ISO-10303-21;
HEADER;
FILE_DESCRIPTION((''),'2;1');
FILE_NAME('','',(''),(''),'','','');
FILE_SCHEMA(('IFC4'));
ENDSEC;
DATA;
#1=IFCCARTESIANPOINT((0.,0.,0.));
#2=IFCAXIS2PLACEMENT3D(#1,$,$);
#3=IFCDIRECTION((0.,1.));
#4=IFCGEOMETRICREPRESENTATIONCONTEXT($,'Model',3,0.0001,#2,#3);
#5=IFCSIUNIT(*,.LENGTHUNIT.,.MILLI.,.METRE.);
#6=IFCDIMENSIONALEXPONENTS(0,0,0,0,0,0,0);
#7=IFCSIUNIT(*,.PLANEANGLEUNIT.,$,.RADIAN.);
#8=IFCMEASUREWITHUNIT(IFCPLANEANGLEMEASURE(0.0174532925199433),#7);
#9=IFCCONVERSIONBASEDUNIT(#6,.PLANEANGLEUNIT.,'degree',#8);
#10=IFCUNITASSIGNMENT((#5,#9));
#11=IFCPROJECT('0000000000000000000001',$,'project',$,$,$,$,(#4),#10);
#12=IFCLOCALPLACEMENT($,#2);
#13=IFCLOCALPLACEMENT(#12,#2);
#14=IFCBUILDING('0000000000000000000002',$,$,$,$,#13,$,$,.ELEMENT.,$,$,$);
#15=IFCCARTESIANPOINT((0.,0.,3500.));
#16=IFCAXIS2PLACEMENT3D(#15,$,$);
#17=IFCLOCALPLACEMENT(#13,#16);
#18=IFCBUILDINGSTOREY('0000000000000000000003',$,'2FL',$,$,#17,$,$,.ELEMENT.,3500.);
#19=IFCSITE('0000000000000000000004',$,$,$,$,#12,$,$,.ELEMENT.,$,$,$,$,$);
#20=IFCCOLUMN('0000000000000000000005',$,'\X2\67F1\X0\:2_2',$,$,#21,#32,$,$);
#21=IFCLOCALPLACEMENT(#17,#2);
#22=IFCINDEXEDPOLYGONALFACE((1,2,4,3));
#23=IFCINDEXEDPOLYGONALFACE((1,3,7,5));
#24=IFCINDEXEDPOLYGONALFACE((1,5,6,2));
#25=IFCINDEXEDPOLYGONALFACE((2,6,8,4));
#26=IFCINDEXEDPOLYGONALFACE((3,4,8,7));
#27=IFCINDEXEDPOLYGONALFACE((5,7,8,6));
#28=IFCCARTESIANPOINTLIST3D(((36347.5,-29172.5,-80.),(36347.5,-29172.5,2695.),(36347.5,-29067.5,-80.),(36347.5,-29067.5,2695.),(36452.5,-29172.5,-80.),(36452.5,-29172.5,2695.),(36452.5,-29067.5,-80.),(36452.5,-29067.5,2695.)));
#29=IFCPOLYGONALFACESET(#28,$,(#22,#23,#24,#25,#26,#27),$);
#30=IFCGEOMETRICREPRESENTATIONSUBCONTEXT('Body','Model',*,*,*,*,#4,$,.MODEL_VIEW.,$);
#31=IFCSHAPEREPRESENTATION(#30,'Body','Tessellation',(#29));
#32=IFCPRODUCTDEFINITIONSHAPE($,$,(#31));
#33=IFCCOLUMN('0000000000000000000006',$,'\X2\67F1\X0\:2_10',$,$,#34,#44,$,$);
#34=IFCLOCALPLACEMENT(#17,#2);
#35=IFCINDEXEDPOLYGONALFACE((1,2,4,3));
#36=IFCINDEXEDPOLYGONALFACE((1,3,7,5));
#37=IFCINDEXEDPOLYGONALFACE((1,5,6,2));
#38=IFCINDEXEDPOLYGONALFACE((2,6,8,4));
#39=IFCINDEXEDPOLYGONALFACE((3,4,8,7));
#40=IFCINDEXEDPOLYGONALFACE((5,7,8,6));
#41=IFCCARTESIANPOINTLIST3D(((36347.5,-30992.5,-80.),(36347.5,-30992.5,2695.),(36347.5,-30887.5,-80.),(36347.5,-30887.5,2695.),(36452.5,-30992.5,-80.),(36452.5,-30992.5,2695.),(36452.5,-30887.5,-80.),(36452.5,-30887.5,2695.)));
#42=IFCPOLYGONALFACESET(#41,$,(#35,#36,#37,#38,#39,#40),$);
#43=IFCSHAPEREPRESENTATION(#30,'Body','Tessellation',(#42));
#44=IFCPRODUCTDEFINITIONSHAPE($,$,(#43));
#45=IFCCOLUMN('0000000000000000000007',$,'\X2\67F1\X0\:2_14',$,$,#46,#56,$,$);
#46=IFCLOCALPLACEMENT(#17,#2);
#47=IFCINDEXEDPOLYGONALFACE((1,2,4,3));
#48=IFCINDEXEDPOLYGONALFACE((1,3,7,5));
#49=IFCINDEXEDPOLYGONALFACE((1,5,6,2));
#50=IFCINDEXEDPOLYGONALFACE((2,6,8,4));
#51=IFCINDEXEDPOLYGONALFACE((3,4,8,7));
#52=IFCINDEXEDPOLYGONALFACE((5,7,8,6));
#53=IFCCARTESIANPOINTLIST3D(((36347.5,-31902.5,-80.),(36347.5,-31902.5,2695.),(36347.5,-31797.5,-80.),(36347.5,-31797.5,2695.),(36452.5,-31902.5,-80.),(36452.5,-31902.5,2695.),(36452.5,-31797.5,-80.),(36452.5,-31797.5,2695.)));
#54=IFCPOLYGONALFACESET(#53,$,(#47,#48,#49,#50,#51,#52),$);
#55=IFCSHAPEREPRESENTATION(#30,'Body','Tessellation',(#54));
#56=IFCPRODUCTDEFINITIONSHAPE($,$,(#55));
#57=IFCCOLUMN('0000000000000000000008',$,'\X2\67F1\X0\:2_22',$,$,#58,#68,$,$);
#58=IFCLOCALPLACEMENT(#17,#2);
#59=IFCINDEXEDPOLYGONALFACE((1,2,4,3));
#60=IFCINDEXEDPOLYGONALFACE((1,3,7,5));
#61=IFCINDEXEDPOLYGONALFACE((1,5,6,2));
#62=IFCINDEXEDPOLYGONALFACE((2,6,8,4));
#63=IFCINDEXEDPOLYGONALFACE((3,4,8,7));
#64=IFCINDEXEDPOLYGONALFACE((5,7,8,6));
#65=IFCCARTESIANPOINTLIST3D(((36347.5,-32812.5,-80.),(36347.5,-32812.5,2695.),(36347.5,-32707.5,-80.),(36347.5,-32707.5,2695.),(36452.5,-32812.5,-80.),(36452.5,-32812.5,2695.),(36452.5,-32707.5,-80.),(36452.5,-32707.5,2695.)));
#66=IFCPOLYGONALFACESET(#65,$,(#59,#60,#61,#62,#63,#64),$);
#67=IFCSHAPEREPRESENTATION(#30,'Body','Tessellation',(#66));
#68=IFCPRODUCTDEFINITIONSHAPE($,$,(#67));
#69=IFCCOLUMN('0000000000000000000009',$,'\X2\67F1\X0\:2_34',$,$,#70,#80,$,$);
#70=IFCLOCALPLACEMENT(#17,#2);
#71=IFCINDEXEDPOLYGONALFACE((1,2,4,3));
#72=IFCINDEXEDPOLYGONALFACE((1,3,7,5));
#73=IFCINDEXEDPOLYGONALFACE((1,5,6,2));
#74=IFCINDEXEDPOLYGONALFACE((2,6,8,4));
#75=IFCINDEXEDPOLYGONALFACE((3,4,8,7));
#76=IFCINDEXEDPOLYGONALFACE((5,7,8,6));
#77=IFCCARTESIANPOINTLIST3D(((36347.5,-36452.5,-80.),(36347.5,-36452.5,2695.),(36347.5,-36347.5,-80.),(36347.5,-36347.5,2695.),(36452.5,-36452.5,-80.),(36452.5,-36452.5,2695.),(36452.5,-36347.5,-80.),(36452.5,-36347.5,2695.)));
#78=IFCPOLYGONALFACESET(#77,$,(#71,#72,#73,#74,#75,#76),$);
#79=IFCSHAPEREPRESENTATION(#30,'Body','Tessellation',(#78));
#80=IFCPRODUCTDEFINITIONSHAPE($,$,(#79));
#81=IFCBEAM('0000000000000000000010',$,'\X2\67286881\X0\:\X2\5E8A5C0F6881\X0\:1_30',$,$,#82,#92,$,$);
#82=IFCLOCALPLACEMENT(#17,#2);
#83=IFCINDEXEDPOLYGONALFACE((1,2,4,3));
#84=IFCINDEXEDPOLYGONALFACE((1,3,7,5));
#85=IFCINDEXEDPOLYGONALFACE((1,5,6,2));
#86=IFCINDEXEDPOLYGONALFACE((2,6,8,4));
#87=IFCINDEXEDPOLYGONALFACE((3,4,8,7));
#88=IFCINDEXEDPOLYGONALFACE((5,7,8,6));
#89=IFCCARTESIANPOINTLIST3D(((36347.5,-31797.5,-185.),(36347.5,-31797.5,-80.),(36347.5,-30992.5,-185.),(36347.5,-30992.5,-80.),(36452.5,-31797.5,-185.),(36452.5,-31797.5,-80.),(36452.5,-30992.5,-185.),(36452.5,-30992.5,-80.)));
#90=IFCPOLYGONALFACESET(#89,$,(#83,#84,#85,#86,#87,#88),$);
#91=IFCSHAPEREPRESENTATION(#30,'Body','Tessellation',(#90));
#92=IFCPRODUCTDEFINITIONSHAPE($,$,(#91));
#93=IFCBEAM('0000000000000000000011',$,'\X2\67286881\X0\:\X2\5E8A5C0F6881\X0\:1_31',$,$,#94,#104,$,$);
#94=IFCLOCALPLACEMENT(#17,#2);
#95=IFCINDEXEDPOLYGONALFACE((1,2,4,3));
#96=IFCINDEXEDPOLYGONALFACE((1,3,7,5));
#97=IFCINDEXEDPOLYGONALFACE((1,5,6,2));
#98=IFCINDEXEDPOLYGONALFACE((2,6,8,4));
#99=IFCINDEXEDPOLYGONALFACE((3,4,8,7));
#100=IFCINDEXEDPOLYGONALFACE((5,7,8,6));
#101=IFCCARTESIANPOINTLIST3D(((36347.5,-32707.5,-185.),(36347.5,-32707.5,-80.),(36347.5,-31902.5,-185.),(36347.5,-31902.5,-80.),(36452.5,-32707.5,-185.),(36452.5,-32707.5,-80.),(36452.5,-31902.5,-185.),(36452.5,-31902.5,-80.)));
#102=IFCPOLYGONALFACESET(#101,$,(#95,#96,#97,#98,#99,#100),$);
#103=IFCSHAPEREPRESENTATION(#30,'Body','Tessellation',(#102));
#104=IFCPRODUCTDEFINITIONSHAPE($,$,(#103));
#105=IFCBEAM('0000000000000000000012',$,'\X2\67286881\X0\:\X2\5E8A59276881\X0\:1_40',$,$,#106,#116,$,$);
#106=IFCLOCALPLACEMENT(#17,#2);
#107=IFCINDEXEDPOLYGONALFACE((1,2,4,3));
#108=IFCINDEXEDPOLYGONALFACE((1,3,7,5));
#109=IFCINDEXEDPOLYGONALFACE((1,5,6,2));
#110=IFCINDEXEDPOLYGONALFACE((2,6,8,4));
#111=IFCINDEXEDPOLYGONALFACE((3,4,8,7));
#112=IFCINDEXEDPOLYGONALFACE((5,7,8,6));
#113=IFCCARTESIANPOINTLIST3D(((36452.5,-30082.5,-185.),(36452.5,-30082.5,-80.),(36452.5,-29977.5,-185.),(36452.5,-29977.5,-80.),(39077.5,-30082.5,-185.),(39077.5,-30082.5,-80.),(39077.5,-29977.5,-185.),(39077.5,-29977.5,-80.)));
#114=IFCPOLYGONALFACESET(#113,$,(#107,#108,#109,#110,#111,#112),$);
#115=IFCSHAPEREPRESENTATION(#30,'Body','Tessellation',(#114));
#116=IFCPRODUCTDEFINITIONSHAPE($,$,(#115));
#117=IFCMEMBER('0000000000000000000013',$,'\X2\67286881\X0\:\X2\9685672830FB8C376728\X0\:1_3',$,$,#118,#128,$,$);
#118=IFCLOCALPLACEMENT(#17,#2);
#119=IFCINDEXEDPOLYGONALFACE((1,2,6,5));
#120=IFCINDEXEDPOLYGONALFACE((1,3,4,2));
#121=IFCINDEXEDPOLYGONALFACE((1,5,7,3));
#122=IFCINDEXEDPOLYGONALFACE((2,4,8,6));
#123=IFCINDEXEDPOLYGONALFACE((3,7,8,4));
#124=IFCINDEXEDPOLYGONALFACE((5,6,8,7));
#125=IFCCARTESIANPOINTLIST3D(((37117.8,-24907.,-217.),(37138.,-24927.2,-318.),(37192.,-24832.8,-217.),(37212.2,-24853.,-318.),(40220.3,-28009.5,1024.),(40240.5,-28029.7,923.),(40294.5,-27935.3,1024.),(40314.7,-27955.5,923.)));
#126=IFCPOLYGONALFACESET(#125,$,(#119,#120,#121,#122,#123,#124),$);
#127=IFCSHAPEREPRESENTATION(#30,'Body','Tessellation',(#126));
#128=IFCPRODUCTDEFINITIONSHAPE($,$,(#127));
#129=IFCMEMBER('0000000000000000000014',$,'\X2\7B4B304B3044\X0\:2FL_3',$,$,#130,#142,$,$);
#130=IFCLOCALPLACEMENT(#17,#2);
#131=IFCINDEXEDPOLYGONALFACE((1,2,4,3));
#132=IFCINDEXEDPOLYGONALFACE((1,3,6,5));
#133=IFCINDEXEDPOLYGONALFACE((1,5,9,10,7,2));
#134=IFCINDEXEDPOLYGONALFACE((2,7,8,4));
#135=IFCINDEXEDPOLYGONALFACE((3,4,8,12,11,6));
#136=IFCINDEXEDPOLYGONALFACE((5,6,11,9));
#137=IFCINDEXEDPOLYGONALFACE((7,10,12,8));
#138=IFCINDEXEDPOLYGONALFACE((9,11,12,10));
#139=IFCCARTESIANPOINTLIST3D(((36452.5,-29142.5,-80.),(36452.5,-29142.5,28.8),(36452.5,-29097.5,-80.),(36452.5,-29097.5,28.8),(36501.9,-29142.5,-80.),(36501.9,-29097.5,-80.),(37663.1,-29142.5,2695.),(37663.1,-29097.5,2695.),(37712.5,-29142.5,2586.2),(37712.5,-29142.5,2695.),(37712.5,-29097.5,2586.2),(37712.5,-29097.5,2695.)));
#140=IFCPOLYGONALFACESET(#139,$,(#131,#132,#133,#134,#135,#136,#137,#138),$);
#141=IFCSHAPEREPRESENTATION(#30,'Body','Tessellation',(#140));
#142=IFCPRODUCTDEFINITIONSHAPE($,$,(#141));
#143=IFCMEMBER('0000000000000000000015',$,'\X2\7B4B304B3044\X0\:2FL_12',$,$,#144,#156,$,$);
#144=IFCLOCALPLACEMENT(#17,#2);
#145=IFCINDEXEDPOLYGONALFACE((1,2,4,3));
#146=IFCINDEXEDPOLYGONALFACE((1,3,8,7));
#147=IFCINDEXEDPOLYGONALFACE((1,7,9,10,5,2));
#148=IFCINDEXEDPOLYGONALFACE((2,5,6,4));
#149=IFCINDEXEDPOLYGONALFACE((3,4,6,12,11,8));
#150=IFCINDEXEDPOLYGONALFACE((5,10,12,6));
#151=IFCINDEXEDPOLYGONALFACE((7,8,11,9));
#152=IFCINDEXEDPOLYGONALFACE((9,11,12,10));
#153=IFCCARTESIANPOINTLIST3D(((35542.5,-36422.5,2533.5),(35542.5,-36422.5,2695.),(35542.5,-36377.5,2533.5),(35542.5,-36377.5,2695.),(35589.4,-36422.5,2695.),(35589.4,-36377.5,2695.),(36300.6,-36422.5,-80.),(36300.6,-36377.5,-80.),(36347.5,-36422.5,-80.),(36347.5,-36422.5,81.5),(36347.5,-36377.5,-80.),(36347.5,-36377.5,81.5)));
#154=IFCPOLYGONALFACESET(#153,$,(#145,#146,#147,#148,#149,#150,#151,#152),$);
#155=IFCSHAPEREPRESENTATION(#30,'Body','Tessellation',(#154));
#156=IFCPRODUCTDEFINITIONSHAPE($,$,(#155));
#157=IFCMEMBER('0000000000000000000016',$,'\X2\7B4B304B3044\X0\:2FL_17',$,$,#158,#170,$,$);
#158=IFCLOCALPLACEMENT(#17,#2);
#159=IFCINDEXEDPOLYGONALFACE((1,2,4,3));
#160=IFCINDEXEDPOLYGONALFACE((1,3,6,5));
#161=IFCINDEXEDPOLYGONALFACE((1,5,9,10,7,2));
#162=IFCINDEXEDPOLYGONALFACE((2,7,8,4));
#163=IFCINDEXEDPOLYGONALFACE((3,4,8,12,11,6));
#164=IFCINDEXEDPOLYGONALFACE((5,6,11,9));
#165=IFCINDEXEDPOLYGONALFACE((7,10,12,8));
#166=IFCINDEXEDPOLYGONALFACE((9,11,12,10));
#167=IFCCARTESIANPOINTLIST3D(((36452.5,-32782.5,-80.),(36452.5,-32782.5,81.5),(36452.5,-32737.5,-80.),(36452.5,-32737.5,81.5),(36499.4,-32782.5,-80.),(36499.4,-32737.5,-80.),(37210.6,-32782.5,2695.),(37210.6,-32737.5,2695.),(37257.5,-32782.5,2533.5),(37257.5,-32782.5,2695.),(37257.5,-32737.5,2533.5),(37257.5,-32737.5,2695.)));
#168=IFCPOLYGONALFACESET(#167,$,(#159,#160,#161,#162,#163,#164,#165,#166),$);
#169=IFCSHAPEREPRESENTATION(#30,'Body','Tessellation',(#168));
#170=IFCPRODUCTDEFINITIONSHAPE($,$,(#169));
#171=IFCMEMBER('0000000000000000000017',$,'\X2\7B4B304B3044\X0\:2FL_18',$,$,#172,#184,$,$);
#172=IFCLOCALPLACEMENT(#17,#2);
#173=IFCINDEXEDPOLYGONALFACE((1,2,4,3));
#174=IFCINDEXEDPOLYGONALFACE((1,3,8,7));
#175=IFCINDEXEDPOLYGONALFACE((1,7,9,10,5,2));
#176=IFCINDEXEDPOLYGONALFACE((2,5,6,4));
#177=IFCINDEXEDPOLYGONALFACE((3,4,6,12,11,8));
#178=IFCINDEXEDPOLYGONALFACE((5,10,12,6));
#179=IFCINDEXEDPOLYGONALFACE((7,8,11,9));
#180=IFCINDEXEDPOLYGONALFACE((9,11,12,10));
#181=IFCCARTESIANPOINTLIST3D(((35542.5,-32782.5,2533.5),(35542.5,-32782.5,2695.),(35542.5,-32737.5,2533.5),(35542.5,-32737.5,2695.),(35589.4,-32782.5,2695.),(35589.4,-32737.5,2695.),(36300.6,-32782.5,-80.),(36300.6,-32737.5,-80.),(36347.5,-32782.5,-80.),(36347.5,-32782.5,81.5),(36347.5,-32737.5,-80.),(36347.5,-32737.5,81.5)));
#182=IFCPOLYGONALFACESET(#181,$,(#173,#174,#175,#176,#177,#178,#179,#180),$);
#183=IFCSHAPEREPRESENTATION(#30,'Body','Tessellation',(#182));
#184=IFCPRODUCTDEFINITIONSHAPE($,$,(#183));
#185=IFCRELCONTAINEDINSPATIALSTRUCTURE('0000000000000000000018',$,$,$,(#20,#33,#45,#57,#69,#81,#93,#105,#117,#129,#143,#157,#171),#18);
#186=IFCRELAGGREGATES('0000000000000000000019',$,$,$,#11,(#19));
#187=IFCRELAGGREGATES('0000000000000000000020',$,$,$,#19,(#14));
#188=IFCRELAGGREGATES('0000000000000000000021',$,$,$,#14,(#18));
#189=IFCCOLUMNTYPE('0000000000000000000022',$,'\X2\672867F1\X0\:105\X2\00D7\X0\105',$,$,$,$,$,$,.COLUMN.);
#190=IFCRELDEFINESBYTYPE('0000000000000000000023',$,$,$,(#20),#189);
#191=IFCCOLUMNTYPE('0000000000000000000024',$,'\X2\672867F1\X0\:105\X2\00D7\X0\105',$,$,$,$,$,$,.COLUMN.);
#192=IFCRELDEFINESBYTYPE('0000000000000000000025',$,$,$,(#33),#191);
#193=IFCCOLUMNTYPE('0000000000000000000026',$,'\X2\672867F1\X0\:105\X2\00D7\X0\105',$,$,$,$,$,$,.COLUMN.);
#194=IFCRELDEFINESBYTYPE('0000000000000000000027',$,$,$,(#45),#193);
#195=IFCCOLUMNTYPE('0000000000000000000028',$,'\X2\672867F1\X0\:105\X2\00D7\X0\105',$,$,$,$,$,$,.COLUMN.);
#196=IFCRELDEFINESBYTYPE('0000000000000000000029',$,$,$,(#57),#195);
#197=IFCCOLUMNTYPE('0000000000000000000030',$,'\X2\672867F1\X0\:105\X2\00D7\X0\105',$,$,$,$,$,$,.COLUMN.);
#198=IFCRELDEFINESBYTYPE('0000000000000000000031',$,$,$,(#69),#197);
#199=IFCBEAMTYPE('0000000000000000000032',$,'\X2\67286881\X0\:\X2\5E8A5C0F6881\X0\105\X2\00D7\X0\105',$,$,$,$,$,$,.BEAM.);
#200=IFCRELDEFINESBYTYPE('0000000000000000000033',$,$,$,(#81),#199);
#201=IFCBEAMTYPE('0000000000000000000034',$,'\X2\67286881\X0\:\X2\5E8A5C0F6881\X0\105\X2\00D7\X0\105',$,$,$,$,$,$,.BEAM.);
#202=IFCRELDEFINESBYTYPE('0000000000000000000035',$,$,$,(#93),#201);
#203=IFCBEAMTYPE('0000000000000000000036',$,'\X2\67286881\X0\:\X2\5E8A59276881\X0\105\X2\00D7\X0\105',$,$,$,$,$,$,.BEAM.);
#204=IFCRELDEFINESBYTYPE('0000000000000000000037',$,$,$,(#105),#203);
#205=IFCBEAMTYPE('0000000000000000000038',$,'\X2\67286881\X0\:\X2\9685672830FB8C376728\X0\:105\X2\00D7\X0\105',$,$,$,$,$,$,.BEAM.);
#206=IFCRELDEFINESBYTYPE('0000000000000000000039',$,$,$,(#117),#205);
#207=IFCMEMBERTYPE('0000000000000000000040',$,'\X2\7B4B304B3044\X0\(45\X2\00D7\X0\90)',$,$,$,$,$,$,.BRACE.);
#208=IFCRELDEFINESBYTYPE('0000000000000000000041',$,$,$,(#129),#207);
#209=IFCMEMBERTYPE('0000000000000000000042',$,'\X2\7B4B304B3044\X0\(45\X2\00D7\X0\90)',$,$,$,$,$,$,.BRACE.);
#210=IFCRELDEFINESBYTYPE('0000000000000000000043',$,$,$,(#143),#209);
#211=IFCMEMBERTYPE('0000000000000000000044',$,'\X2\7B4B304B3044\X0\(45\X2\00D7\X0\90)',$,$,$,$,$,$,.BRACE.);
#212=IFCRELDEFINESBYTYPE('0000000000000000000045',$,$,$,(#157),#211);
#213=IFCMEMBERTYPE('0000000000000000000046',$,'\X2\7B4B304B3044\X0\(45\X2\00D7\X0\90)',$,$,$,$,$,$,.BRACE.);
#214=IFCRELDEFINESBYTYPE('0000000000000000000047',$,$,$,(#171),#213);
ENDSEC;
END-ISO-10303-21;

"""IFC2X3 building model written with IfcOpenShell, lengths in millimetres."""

from ifc_helpers import new_model, entity, si_unit, converted_unit, direction, frame, origin, origin_with_axes, origin_2d, place, context, subcontext, project, spatial, polyline, rectangle, outline, extrude, type_object, element, save


model = new_model("IFC2X3")

# Units and contexts
model_context = context("Model", 3, precision=0.0001, world=origin(), true_north=direction((0.0, 1.0)))
body_context = subcontext(model_context, "Body", "Model", "MODEL_VIEW")
ifc_project = project(units=[si_unit("LENGTHUNIT", "METRE", prefix="MILLI"), converted_unit("PLANEANGLEUNIT", "degree", entity("IfcPlaneAngleMeasure", 0.0174532925199433), si_unit("PLANEANGLEUNIT", "RADIAN"), dimensions=[0, 0, 0, 0, 0, 0, 0])], contexts=[model_context])

# Site, building, storey
site_placement = place(None, origin())
site = spatial("IfcSite", under=ifc_project, at=site_placement, CompositionType="ELEMENT")
building_placement = place(site_placement, origin())
building = spatial("IfcBuilding", under=site, at=building_placement, CompositionType="ELEMENT")
storey_placement = place(building_placement, frame((0.0, 0.0, 3500.0)))
storey = spatial("IfcBuildingStorey", under=building, at=storey_placement, Name="2FL", CompositionType="ELEMENT", Elevation=3500.0)

# Columns
column_type_1 = type_object("IfcColumnType", Name="木柱:105×105", PredefinedType="COLUMN")
column_1_placement = place(storey_placement, frame((36400.0, -29120.0, -80.0)))
element("IfcColumn", 1, at=column_1_placement, inside=storey, type_object=column_type_1, Name="柱:2_2", context=body_context, shape_type="SweptSolid", body=[
    extrude(rectangle(XDim=105.0, YDim=105.0, at=origin_2d()), origin_with_axes(), (0.0, 0.0, 1.0), 2775.0),
])
column_type_2 = type_object("IfcColumnType", Name="木柱:105×105", PredefinedType="COLUMN")
column_2_placement = place(storey_placement, frame((36400.0, -30940.0, -80.0)))
element("IfcColumn", 2, at=column_2_placement, inside=storey, type_object=column_type_2, Name="柱:2_10", context=body_context, shape_type="SweptSolid", body=[
    extrude(rectangle(XDim=105.0, YDim=105.0, at=origin_2d()), origin_with_axes(), (0.0, 0.0, 1.0), 2775.0),
])
column_type_3 = type_object("IfcColumnType", Name="木柱:105×105", PredefinedType="COLUMN")
column_3_placement = place(storey_placement, frame((36400.0, -31850.0, -80.0)))
element("IfcColumn", 3, at=column_3_placement, inside=storey, type_object=column_type_3, Name="柱:2_14", context=body_context, shape_type="SweptSolid", body=[
    extrude(rectangle(XDim=105.0, YDim=105.0, at=origin_2d()), origin_with_axes(), (0.0, 0.0, 1.0), 2775.0),
])
column_type_4 = type_object("IfcColumnType", Name="木柱:105×105", PredefinedType="COLUMN")
column_4_placement = place(storey_placement, frame((36400.0, -32760.0, -80.0)))
element("IfcColumn", 4, at=column_4_placement, inside=storey, type_object=column_type_4, Name="柱:2_22", context=body_context, shape_type="SweptSolid", body=[
    extrude(rectangle(XDim=105.0, YDim=105.0, at=origin_2d()), origin_with_axes(), (0.0, 0.0, 1.0), 2775.0),
])
column_type_5 = type_object("IfcColumnType", Name="木柱:105×105", PredefinedType="COLUMN")
column_5_placement = place(storey_placement, frame((36400.0, -36400.0, -80.0)))
element("IfcColumn", 5, at=column_5_placement, inside=storey, type_object=column_type_5, Name="柱:2_34", context=body_context, shape_type="SweptSolid", body=[
    extrude(rectangle(XDim=105.0, YDim=105.0, at=origin_2d()), origin_with_axes(), (0.0, 0.0, 1.0), 2775.0),
])

# Beams
beam_type_1 = type_object("IfcBeamType", Name="木梁:床小梁105×105", PredefinedType="BEAM")
beam_1_placement = place(storey_placement, frame((36400.0, -30992.5, -132.5), z_axis=(0.0, -1.0, 0.0), x_axis=(1.0, 0.0, 0.0)))
element("IfcBeam", 6, at=beam_1_placement, inside=storey, type_object=beam_type_1, Name="木梁:床小梁:1_30", context=body_context, shape_type="SweptSolid", body=[
    extrude(rectangle(XDim=105.0, YDim=105.0, at=origin_2d()), origin_with_axes(), (0.0, 0.0, 1.0), 805.0),
])
beam_type_2 = type_object("IfcBeamType", Name="木梁:床小梁105×105", PredefinedType="BEAM")
beam_2_placement = place(storey_placement, frame((36400.0, -31902.5, -132.5), z_axis=(0.0, -1.0, 0.0), x_axis=(1.0, 0.0, 0.0)))
element("IfcBeam", 7, at=beam_2_placement, inside=storey, type_object=beam_type_2, Name="木梁:床小梁:1_31", context=body_context, shape_type="SweptSolid", body=[
    extrude(rectangle(XDim=105.0, YDim=105.0, at=origin_2d()), origin_with_axes(), (0.0, 0.0, 1.0), 805.0),
])
beam_type_3 = type_object("IfcBeamType", Name="木梁:床大梁105×105", PredefinedType="BEAM")
beam_3_placement = place(storey_placement, frame((36452.5, -30030.0, -132.5), z_axis=(1.0, 0.0, 0.0), x_axis=(0.0, 1.0, 0.0)))
element("IfcBeam", 8, at=beam_3_placement, inside=storey, type_object=beam_type_3, Name="木梁:床大梁:1_40", context=body_context, shape_type="SweptSolid", body=[
    extrude(rectangle(XDim=105.0, YDim=105.0, at=origin_2d()), origin_with_axes(), (0.0, 0.0, 1.0), 2625.0),
])

# Members
beam_type_4 = type_object("IfcBeamType", Name="木梁:隅木・谷木:105×105", PredefinedType="BEAM")
member_1_placement = place(storey_placement, frame((37165.0, -24880.0, -267.5), z_axis=(0.680414, -0.680414, 0.272166), x_axis=(-0.707107, -0.707107, 0.0)))
element("IfcMember", 9, at=member_1_placement, inside=storey, type_object=beam_type_4, Name="木梁:隅木・谷木:1_3", context=body_context, shape_type="SweptSolid", body=[
    extrude(rectangle(XDim=105.0, YDim=105.0, at=origin_2d()), origin_with_axes(), (0.0, 0.0, 1.0), 4559.7),
])
member_type_1 = type_object("IfcMemberType", Name="筋かい(45×90)", PredefinedType="BRACE")
member_2_placement = place(storey_placement, frame((36452.5, -29120.0, -80.0), z_axis=(0.413432, 0.0, 0.910535), x_axis=(-0.910535, 0.0, 0.413432)))
element("IfcMember", 10, at=member_2_placement, inside=storey, type_object=member_type_1, Name="筋かい:2FL_3", context=body_context, shape_type="SweptSolid", body=[
    extrude(outline(polyline([(0.0, 0.0), (20.4, -45.0), (2948.6, -45.0), (3047.7, 0.0), (3027.2, 45.0), (99.1, 45.0), (0.0, 0.0)])), frame((0.0, -22.5, 0.0), z_axis=(0.0, 1.0, 0.0), x_axis=(0.0, 0.0, 1.0)), (0.0, 0.0, 1.0), 45.0),
])
member_type_2 = type_object("IfcMemberType", Name="筋かい(45×90)", PredefinedType="BRACE")
member_3_placement = place(storey_placement, frame((36347.5, -36400.0, -80.0), z_axis=(-0.278604, 0.0, 0.960406), x_axis=(0.960406, 0.0, 0.278604)))
element("IfcMember", 11, at=member_3_placement, inside=storey, type_object=member_type_2, Name="筋かい:2FL_12", context=body_context, shape_type="SweptSolid", body=[
    extrude(outline(polyline([(0.0, 0.0), (13.1, -45.0), (2734.3, -45.0), (2889.4, 0.0), (2876.3, 45.0), (155.1, 45.0), (0.0, 0.0)])), frame((0.0, -22.5, 0.0), z_axis=(0.0, 1.0, 0.0), x_axis=(0.0, 0.0, 1.0)), (0.0, 0.0, 1.0), 45.0),
])
member_type_3 = type_object("IfcMemberType", Name="筋かい(45×90)", PredefinedType="BRACE")
member_4_placement = place(storey_placement, frame((36452.5, -32760.0, -80.0), z_axis=(0.278604, 0.0, 0.960406), x_axis=(-0.960406, 0.0, 0.278604)))
element("IfcMember", 12, at=member_4_placement, inside=storey, type_object=member_type_3, Name="筋かい:2FL_17", context=body_context, shape_type="SweptSolid", body=[
    extrude(outline(polyline([(0.0, 0.0), (13.1, -45.0), (2734.3, -45.0), (2889.4, 0.0), (2876.3, 45.0), (155.1, 45.0), (0.0, 0.0)])), frame((0.0, -22.5, 0.0), z_axis=(0.0, 1.0, 0.0), x_axis=(0.0, 0.0, 1.0)), (0.0, 0.0, 1.0), 45.0),
])
member_type_4 = type_object("IfcMemberType", Name="筋かい(45×90)", PredefinedType="BRACE")
member_5_placement = place(storey_placement, frame((36347.5, -32760.0, -80.0), z_axis=(-0.278604, 0.0, 0.960406), x_axis=(0.960406, 0.0, 0.278604)))
element("IfcMember", 13, at=member_5_placement, inside=storey, type_object=member_type_4, Name="筋かい:2FL_18", context=body_context, shape_type="SweptSolid", body=[
    extrude(outline(polyline([(0.0, 0.0), (13.1, -45.0), (2734.3, -45.0), (2889.4, 0.0), (2876.3, 45.0), (155.1, 45.0), (0.0, 0.0)])), frame((0.0, -22.5, 0.0), z_axis=(0.0, 1.0, 0.0), x_axis=(0.0, 0.0, 1.0)), (0.0, 0.0, 1.0), 45.0),
])

save(model, "model.ifc")
